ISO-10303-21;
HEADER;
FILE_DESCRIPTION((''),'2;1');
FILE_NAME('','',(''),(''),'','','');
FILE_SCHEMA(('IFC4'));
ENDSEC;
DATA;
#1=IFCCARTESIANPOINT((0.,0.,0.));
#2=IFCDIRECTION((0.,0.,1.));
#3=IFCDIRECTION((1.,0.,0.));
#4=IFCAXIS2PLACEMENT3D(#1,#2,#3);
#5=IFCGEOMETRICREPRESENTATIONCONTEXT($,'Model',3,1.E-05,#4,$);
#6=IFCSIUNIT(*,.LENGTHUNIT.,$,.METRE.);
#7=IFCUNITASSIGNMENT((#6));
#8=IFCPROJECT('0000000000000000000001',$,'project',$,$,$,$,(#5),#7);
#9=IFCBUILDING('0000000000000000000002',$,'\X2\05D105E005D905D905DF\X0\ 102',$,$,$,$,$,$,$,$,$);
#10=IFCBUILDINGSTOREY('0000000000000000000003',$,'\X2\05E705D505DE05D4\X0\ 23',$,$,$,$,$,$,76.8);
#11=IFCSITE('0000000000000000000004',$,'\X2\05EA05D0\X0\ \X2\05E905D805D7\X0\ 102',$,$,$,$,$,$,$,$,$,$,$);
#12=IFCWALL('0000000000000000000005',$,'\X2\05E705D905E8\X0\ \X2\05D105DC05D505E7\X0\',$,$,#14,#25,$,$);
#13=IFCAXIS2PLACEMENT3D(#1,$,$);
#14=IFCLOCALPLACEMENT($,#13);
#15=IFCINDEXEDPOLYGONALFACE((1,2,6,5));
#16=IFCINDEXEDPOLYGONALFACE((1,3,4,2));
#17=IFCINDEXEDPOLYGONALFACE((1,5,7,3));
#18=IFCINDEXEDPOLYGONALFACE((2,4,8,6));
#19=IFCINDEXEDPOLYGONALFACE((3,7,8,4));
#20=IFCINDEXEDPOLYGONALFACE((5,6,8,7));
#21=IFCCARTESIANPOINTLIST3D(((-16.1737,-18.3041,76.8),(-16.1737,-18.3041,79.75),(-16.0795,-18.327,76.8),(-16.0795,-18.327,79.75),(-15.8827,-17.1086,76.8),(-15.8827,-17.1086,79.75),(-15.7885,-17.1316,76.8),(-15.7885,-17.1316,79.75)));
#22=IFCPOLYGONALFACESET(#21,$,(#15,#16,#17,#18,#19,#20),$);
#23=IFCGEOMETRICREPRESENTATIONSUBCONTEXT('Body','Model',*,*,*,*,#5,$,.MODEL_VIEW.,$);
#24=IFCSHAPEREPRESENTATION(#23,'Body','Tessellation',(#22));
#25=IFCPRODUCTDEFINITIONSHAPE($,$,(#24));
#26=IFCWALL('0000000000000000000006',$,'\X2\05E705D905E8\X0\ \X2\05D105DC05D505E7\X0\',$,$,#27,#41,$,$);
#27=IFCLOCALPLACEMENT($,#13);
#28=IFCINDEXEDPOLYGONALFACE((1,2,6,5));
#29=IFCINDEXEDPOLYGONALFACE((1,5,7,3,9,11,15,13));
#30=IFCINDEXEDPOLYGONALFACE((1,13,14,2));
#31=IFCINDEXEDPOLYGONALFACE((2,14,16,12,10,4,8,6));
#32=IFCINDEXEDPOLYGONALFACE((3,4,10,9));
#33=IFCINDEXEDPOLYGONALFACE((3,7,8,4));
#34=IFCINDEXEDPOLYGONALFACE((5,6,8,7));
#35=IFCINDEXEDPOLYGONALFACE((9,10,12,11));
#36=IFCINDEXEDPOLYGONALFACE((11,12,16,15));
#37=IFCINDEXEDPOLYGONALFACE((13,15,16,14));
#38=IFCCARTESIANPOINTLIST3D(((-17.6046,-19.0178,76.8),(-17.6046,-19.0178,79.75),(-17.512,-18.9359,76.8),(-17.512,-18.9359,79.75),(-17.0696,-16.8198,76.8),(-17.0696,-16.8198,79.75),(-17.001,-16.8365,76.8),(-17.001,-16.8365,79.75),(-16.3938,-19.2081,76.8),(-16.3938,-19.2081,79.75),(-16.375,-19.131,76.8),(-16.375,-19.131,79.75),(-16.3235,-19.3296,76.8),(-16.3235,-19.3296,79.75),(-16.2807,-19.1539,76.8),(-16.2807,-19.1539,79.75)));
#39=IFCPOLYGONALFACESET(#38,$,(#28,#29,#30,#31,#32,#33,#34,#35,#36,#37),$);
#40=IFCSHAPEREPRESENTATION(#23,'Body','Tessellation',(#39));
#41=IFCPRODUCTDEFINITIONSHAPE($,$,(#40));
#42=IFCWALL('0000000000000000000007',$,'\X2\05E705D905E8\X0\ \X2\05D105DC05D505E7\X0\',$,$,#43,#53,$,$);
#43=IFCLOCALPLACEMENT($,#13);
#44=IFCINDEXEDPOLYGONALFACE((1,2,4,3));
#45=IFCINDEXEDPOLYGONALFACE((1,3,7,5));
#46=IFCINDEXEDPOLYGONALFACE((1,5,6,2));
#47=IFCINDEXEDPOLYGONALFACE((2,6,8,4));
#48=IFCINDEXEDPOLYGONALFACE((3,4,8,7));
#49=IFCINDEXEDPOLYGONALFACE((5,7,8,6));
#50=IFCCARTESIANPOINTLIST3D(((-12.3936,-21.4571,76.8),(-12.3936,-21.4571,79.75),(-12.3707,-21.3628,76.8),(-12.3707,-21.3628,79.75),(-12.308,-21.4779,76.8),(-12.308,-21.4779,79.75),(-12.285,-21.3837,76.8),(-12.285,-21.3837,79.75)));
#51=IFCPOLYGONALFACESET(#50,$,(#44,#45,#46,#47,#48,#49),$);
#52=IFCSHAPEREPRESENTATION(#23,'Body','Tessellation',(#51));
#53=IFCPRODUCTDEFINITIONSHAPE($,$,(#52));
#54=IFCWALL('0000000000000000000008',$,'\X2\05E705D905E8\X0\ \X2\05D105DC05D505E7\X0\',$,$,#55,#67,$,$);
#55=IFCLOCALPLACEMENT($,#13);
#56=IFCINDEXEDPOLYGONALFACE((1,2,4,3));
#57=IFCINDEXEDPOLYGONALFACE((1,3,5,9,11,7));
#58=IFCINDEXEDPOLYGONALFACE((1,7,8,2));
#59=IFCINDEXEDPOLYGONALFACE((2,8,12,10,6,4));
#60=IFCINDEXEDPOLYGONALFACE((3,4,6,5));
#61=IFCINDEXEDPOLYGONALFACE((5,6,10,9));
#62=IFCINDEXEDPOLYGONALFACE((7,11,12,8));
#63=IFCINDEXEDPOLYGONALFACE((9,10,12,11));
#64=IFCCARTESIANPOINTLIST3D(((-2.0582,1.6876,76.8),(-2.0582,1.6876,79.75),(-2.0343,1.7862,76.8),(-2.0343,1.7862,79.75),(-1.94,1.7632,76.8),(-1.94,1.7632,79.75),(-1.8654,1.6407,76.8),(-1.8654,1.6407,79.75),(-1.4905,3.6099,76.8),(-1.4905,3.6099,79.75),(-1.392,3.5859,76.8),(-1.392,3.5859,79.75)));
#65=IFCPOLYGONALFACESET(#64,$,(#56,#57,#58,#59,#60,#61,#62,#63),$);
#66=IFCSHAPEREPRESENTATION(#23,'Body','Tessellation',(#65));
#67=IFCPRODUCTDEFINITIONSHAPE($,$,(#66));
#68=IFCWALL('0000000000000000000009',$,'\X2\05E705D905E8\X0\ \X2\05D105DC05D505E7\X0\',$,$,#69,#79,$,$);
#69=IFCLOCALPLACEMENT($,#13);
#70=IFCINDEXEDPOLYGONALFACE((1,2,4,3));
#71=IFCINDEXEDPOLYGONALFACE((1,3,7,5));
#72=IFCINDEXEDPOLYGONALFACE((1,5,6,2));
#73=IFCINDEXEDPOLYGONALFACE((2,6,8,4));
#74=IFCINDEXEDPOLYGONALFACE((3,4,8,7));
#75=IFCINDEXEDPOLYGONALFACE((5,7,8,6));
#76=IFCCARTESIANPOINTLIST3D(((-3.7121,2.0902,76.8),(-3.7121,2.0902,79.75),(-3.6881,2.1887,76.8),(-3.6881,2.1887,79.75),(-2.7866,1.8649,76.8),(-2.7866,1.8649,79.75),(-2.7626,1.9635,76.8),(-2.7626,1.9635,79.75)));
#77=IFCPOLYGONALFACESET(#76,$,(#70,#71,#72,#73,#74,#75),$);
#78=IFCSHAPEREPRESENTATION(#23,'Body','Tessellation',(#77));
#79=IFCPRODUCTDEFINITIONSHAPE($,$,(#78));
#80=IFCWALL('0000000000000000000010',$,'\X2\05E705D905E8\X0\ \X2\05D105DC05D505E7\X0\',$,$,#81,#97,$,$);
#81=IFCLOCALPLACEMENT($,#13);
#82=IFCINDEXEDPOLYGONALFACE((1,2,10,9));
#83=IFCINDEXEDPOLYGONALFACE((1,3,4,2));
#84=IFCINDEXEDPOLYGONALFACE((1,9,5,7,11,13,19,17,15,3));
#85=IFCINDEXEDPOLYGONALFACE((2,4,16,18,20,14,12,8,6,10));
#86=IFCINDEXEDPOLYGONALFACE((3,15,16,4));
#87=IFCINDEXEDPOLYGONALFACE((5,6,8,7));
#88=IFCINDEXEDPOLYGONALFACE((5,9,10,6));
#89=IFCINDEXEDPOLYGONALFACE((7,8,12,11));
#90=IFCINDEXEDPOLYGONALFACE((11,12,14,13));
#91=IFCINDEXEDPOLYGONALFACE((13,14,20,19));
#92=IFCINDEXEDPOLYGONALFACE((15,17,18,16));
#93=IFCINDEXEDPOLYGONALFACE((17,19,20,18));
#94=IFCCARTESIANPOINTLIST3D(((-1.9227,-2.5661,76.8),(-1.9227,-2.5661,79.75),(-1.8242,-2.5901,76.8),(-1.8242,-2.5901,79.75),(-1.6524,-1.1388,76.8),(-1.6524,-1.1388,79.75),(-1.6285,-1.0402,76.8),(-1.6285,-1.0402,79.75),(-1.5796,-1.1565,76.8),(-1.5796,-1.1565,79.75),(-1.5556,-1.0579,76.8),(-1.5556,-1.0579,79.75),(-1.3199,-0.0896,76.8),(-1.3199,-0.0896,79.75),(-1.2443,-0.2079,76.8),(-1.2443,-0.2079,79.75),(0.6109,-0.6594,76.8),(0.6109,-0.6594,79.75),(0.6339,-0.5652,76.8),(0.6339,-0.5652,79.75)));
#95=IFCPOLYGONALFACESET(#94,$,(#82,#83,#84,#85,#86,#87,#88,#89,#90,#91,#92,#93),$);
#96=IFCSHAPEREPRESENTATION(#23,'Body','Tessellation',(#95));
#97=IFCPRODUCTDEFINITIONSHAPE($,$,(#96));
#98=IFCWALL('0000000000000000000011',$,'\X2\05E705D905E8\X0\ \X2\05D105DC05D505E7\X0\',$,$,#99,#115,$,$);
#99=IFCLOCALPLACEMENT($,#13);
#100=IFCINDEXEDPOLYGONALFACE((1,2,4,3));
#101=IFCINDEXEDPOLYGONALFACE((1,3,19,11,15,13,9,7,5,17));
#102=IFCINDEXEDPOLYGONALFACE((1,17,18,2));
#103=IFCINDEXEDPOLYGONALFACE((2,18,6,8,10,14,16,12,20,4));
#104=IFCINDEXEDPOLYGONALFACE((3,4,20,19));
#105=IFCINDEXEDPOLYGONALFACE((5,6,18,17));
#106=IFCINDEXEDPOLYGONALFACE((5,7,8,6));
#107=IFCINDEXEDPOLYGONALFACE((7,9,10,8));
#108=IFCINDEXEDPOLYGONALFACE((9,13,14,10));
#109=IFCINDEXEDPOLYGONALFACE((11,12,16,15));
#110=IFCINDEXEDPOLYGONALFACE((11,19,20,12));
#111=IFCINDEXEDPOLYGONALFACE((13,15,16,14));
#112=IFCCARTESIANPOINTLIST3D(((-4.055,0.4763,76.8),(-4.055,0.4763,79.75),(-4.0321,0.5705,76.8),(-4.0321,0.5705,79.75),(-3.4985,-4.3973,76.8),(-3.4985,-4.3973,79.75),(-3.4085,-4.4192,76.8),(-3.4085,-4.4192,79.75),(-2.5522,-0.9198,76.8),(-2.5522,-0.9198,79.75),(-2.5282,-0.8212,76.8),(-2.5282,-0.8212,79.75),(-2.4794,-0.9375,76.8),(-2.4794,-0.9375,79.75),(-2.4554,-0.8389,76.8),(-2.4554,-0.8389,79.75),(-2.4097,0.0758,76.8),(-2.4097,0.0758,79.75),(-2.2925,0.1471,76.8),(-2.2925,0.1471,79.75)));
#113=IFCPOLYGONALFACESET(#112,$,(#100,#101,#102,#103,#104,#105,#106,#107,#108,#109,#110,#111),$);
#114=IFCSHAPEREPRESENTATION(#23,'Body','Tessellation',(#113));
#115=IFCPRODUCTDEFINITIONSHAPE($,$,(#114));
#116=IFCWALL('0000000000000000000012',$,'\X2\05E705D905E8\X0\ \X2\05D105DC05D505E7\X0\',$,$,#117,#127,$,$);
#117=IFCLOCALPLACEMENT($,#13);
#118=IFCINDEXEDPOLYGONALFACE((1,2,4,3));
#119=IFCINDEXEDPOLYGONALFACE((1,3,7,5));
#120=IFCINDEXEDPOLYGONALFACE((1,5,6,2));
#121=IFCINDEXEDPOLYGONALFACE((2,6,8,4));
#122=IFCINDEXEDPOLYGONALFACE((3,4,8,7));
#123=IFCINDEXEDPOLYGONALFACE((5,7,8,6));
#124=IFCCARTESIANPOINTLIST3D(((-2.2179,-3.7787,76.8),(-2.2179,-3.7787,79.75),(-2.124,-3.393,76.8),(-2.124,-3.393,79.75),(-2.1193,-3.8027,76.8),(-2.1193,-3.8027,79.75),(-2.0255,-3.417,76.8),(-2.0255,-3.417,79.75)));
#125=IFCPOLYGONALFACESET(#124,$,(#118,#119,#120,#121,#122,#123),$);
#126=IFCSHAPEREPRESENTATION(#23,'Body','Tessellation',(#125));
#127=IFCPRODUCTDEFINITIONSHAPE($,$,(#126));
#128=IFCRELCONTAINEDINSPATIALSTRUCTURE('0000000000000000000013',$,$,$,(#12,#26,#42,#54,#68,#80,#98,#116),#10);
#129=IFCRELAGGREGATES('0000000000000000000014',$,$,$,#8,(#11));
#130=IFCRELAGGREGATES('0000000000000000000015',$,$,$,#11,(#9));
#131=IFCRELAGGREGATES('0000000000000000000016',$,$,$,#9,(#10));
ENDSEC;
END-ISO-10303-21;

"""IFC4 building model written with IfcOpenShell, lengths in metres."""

from ifc_helpers import new_model, si_unit, frame, origin_with_axes, context, subcontext, project, spatial, polyline, outline, extrude, element, save


model = new_model("IFC4")

# Units and contexts
model_context = context("Model", 3, precision=1e-05, world=origin_with_axes())
body_context = subcontext(model_context, "Body", "Model", "MODEL_VIEW")
ifc_project = project(units=[si_unit("LENGTHUNIT", "METRE")], contexts=[model_context])

# Site, building, storey
site = spatial("IfcSite", under=ifc_project, Name="תא שטח 102")
building = spatial("IfcBuilding", under=site, Name="בניין 102")
storey = spatial("IfcBuildingStorey", under=building, Name="קומה 23", Elevation=76.8)

# Walls
element("IfcWall", 1, inside=storey, Name="קיר בלוק", context=body_context, shape_type="SweptSolid", body=[
    extrude(outline(polyline([(-16.1737, -18.3041), (-16.0795, -18.327), (-15.7885, -17.1316), (-15.8827, -17.1086), (-16.1737, -18.3041)])), frame((0.0, 0.0, 76.8)), (0.0, 0.0, 1.0), 2.95),
])
element("IfcWall", 2, inside=storey, Name="קיר בלוק", context=body_context, shape_type="SweptSolid", body=[
    extrude(outline(polyline([(-17.6046, -19.0178), (-16.3235, -19.3296), (-16.2807, -19.1539), (-16.375, -19.131), (-16.3938, -19.2081), (-17.512, -18.9359), (-17.001, -16.8365), (-17.0696, -16.8198), (-17.6046, -19.0178)])), frame((0.0, 0.0, 76.8)), (0.0, 0.0, 1.0), 2.95),
])
element("IfcWall", 3, inside=storey, Name="קיר בלוק", context=body_context, shape_type="SweptSolid", body=[
    extrude(outline(polyline([(-12.285, -21.3837), (-12.3707, -21.3628), (-12.3936, -21.4571), (-12.308, -21.4779), (-12.285, -21.3837)])), frame((0.0, 0.0, 76.8)), (0.0, 0.0, 1.0), 2.95),
])
element("IfcWall", 4, inside=storey, Name="קיר בלוק", context=body_context, shape_type="SweptSolid", body=[
    extrude(outline(polyline([(-2.0582, 1.6876), (-1.8654, 1.6407), (-1.392, 3.5859), (-1.4905, 3.6099), (-1.94, 1.7632), (-2.0343, 1.7862), (-2.0582, 1.6876)])), frame((0.0, 0.0, 76.8)), (0.0, 0.0, 1.0), 2.95),
])
element("IfcWall", 5, inside=storey, Name="קיר בלוק", context=body_context, shape_type="SweptSolid", body=[
    extrude(outline(polyline([(-2.7626, 1.9635), (-3.6881, 2.1887), (-3.7121, 2.0902), (-2.7866, 1.8649), (-2.7626, 1.9635)])), frame((0.0, 0.0, 76.8)), (0.0, 0.0, 1.0), 2.95),
])
element("IfcWall", 6, inside=storey, Name="קיר בלוק", context=body_context, shape_type="SweptSolid", body=[
    extrude(outline(polyline([(-1.6524, -1.1388), (-1.5796, -1.1565), (-1.9227, -2.5661), (-1.8242, -2.5901), (-1.2443, -0.2079), (0.6109, -0.6594), (0.6339, -0.5652), (-1.3199, -0.0896), (-1.5556, -1.0579), (-1.6285, -1.0402), (-1.6524, -1.1388)])), frame((0.0, 0.0, 76.8)), (0.0, 0.0, 1.0), 2.95),
])
element("IfcWall", 7, inside=storey, Name="קיר בלוק", context=body_context, shape_type="SweptSolid", body=[
    extrude(outline(polyline([(-3.4085, -4.4192), (-2.5522, -0.9198), (-2.4794, -0.9375), (-2.4554, -0.8389), (-2.5282, -0.8212), (-2.2925, 0.1471), (-4.0321, 0.5705), (-4.055, 0.4763), (-2.4097, 0.0758), (-3.4985, -4.3973), (-3.4085, -4.4192)])), frame((0.0, 0.0, 76.8)), (0.0, 0.0, 1.0), 2.95),
])
element("IfcWall", 8, inside=storey, Name="קיר בלוק", context=body_context, shape_type="SweptSolid", body=[
    extrude(outline(polyline([(-2.0255, -3.417), (-2.124, -3.393), (-2.2179, -3.7787), (-2.1193, -3.8027), (-2.0255, -3.417)])), frame((0.0, 0.0, 76.8)), (0.0, 0.0, 1.0), 2.95),
])

save(model, "model.ifc")
